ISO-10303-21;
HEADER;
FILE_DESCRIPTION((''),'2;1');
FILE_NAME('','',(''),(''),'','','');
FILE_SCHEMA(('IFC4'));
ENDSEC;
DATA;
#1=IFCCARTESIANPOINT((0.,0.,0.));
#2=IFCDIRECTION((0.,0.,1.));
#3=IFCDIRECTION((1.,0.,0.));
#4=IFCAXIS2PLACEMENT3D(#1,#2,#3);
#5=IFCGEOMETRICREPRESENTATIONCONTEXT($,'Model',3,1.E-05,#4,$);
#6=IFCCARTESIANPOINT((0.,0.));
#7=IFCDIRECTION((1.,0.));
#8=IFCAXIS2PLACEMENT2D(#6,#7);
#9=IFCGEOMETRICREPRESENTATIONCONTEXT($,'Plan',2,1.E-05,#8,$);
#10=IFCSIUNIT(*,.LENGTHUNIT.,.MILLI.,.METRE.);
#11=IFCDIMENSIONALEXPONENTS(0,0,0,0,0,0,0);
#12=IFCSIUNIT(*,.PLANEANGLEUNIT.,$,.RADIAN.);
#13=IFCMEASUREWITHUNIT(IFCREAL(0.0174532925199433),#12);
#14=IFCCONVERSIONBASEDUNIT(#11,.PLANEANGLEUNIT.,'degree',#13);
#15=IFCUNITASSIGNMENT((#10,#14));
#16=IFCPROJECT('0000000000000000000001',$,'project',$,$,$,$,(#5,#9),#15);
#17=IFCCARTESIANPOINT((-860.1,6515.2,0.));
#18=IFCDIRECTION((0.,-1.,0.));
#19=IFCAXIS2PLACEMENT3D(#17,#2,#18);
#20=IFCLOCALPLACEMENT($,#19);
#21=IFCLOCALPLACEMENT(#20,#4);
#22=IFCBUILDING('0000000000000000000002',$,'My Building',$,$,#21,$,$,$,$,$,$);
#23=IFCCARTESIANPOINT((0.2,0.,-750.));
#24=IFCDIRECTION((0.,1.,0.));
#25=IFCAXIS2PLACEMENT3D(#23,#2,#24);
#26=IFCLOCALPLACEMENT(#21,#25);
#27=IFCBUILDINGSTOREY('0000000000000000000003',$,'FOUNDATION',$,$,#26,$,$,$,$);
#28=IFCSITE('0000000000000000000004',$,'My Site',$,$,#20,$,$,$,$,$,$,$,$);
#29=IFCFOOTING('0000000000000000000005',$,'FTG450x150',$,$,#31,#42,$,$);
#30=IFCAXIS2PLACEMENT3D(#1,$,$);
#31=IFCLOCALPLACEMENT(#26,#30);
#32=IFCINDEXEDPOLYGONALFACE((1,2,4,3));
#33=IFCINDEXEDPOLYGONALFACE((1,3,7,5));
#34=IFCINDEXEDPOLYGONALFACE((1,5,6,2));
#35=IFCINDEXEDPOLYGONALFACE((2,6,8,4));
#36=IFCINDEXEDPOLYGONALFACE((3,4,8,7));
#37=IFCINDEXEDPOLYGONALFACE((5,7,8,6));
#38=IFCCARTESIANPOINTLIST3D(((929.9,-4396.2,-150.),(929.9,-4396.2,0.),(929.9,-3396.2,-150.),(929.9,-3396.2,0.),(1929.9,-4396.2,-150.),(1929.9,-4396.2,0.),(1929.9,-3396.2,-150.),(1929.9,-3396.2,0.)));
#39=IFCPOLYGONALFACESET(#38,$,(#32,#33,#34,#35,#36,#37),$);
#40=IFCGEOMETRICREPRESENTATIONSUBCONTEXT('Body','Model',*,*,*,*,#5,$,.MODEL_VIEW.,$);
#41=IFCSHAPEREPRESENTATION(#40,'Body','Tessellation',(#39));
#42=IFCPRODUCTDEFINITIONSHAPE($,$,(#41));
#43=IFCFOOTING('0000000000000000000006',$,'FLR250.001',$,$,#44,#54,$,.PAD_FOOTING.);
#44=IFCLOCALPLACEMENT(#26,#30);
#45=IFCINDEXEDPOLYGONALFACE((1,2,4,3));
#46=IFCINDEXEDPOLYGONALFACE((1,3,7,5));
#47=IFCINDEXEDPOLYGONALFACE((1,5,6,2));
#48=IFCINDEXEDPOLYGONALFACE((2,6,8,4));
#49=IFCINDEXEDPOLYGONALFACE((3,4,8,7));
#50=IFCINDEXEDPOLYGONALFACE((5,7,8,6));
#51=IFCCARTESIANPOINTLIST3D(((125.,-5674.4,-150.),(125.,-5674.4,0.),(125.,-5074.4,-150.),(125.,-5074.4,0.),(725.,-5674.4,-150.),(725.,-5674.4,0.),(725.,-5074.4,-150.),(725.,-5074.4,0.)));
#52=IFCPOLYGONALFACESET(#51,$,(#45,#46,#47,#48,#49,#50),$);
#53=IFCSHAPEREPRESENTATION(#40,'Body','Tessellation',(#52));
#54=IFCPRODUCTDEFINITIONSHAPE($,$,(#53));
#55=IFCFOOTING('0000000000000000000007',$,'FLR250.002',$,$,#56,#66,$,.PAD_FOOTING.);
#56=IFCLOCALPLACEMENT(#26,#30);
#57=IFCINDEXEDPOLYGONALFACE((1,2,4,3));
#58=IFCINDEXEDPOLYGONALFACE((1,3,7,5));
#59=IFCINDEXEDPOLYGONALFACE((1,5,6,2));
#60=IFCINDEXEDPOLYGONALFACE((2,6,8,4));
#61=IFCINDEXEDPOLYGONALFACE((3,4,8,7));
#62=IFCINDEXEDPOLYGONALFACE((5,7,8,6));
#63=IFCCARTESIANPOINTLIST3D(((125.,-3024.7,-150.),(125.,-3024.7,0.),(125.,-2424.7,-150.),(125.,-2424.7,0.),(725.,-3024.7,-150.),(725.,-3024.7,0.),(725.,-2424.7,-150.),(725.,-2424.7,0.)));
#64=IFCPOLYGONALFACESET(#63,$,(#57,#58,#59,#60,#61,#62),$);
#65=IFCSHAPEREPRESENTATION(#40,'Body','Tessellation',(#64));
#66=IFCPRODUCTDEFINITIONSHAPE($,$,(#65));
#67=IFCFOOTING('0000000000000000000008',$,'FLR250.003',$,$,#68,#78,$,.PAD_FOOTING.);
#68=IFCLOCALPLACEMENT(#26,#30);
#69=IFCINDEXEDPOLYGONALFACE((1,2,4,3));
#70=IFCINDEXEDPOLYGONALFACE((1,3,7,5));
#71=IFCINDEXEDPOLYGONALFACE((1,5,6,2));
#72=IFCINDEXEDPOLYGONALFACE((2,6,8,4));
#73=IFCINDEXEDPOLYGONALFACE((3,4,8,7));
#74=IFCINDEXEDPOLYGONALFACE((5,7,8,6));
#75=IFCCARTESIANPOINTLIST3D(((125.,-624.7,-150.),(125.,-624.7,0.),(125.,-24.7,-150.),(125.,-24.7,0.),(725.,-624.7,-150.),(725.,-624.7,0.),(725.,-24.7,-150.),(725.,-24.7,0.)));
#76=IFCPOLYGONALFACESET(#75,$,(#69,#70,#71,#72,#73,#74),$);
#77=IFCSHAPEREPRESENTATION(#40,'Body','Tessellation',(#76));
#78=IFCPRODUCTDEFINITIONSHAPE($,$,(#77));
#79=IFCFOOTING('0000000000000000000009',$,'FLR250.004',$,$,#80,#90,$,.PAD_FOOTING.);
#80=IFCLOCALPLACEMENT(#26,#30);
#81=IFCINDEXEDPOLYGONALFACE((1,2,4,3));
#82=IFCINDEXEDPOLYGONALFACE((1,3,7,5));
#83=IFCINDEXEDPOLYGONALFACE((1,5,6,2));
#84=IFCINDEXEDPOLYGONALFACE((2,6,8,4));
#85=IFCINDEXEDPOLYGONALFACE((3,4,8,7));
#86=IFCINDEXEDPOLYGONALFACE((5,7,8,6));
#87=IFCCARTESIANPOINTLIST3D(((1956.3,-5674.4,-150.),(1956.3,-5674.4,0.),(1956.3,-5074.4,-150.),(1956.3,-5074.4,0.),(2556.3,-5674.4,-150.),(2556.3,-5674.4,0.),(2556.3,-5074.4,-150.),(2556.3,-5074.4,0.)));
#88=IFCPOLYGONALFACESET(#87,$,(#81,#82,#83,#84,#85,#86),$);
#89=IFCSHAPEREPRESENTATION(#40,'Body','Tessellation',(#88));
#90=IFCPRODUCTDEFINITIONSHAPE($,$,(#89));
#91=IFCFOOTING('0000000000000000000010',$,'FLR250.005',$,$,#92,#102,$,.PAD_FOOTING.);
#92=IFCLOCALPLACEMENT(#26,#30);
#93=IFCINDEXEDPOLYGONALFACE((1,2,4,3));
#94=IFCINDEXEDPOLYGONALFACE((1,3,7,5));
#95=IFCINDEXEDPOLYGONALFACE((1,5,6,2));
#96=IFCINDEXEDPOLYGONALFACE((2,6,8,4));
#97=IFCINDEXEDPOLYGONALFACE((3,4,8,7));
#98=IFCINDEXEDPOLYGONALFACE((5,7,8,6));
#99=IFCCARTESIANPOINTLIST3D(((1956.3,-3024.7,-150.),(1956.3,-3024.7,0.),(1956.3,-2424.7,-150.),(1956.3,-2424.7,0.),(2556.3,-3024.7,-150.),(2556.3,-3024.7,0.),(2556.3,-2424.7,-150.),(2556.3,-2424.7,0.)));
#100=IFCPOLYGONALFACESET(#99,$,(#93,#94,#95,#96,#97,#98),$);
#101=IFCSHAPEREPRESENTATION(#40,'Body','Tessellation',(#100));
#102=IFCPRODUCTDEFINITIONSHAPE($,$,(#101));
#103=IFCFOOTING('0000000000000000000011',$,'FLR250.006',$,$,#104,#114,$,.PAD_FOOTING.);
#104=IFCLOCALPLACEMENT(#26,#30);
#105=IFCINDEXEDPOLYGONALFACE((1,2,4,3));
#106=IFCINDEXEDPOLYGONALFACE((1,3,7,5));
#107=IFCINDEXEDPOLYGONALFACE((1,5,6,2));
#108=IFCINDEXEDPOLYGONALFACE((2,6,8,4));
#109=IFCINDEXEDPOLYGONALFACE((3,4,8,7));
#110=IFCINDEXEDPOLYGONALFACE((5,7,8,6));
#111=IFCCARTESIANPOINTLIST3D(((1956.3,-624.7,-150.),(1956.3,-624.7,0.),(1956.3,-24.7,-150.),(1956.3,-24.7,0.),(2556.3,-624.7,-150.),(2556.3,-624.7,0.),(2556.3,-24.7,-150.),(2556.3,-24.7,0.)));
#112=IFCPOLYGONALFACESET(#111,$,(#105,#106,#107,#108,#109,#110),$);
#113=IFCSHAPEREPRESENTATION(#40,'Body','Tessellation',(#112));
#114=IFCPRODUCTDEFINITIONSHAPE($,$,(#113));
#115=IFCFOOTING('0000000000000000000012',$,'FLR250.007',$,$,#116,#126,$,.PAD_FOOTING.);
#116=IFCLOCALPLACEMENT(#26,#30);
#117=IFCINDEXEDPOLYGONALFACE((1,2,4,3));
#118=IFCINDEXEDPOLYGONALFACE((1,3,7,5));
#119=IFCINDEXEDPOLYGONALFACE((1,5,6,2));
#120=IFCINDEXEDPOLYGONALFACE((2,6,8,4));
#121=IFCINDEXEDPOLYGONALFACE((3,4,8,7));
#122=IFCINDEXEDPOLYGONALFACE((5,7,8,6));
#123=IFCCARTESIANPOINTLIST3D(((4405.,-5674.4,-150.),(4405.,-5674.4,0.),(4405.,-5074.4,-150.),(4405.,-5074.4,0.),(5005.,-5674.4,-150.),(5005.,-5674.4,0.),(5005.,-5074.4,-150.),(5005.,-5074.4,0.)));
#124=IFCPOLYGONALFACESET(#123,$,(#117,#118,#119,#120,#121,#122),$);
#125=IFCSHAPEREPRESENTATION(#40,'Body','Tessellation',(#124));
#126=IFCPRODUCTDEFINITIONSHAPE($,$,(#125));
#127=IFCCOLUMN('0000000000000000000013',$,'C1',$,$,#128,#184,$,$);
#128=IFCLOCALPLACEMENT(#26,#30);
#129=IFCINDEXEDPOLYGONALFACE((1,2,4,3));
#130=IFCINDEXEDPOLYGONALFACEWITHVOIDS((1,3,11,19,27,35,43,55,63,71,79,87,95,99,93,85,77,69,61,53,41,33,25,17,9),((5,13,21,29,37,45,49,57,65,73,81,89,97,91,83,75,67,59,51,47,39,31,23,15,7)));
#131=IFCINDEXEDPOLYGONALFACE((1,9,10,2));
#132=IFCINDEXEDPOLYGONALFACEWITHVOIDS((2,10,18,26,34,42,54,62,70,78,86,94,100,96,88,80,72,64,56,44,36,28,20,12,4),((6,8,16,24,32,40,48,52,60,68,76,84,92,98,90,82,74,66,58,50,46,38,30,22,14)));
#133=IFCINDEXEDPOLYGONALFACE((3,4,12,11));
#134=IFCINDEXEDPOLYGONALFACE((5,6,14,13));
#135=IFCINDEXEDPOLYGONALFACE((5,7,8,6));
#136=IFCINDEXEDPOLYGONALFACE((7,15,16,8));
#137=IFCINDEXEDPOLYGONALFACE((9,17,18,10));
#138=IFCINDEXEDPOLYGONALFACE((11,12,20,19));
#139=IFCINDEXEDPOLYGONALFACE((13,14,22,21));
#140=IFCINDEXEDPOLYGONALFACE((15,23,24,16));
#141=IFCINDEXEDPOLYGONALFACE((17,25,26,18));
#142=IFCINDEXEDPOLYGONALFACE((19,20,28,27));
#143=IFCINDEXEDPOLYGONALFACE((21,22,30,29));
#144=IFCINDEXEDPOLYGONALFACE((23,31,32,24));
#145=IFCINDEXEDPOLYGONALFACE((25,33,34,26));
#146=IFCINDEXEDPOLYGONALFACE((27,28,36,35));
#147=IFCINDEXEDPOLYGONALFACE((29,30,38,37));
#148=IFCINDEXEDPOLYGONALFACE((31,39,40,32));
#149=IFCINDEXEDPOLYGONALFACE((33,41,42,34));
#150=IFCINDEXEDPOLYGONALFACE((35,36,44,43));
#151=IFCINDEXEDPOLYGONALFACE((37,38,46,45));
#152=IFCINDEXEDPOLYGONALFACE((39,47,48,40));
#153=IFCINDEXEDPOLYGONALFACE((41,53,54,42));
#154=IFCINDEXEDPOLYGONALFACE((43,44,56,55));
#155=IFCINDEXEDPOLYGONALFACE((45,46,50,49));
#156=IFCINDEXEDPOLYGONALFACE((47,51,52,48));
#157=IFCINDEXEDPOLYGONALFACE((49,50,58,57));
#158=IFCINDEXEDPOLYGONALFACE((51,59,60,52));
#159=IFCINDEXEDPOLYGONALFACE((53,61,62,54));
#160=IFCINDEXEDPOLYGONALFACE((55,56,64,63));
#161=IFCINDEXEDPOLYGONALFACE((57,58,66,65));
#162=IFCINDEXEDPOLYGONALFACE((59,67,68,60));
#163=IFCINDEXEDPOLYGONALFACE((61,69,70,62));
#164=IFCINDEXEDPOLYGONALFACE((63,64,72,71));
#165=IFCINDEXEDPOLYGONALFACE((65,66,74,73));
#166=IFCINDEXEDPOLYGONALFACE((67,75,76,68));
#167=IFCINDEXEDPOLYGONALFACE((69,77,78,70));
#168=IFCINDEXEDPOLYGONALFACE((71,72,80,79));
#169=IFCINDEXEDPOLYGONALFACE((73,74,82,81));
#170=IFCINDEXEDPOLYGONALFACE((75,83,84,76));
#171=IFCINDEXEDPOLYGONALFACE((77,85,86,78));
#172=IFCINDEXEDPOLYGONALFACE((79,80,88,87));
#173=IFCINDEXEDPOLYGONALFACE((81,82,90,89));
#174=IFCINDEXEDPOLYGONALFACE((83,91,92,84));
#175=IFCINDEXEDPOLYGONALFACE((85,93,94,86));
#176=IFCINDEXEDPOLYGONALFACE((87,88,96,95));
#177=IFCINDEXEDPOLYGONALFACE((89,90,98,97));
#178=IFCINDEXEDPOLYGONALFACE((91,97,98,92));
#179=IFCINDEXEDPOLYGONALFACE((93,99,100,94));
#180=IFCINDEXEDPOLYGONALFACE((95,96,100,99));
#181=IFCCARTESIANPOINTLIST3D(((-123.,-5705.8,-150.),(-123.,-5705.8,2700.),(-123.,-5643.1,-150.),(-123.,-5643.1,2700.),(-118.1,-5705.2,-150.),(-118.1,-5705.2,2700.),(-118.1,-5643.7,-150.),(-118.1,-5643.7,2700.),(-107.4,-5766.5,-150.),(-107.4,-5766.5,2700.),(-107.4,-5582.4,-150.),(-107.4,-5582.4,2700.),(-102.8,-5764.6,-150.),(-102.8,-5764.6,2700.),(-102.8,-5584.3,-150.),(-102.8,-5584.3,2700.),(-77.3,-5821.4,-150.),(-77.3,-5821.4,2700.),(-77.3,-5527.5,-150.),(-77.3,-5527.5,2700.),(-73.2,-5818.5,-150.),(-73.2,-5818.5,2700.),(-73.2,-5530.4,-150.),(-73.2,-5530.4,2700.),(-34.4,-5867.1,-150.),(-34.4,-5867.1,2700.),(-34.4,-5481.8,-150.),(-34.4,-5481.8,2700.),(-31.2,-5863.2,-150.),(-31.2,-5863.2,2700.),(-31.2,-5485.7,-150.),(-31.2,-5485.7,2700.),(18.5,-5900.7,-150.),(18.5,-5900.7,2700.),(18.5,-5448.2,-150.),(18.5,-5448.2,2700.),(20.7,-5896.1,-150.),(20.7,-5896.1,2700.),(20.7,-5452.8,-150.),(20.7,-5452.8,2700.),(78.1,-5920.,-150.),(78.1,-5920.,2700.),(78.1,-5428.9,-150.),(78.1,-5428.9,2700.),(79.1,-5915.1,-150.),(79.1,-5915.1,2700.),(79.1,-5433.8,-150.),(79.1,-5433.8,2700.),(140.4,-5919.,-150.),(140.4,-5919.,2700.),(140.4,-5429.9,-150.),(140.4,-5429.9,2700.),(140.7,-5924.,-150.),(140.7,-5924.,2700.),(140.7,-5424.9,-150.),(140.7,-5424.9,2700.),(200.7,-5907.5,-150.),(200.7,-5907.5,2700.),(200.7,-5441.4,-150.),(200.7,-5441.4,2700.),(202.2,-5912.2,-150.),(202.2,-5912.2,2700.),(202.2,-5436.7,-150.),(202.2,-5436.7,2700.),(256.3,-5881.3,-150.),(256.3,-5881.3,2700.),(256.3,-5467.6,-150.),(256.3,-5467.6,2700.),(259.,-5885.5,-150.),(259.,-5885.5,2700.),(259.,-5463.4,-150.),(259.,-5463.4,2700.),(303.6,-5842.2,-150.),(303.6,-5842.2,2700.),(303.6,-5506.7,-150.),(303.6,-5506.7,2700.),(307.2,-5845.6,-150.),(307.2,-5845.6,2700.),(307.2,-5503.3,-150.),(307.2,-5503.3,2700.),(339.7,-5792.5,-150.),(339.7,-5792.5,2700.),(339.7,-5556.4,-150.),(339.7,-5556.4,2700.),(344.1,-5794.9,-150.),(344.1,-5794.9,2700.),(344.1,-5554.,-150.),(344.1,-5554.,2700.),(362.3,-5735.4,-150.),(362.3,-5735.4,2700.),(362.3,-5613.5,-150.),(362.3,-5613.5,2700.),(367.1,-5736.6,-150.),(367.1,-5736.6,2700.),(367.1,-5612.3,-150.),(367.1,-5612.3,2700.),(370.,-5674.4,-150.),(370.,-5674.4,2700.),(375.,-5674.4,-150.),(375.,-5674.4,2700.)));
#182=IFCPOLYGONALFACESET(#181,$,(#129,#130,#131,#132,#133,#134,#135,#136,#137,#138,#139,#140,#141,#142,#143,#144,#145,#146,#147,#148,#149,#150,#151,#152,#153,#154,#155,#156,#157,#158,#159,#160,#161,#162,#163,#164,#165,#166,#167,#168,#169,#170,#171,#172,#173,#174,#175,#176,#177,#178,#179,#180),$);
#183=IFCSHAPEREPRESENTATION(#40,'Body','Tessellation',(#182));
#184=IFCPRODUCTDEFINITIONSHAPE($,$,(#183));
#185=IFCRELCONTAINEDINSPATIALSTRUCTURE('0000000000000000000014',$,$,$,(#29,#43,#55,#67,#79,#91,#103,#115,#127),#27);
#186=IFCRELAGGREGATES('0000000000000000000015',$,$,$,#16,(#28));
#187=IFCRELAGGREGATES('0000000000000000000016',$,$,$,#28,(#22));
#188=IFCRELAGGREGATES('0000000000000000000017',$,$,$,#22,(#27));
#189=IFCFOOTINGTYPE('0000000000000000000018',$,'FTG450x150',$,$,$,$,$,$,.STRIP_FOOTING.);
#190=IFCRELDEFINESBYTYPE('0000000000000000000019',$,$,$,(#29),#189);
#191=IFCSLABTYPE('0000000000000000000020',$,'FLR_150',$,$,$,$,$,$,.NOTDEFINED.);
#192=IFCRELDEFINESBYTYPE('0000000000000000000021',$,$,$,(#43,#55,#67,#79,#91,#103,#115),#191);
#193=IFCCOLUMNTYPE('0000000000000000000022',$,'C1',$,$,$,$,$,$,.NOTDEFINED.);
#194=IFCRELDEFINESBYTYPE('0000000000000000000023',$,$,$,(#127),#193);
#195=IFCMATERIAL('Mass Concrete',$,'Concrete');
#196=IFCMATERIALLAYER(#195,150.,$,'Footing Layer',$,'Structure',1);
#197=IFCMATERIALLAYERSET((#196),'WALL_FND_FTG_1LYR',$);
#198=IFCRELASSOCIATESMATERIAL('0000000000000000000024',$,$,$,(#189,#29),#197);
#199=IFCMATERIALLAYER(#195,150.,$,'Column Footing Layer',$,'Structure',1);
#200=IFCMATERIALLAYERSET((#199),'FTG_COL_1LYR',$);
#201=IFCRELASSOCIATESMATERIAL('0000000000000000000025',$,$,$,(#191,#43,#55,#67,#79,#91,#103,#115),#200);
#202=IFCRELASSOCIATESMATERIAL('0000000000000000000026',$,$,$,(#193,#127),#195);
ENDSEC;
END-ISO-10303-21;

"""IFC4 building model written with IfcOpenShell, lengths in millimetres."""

from ifc_helpers import new_model, entity, si_unit, converted_unit, frame, origin_with_axes, origin_2d_with_axis, place, context, subcontext, project, spatial, line, indexed_curve, rectangle, hollow_circle, outline, extrude, material, layer, layer_set, layer_usage, material_profile, profile_set, profile_usage, type_object, element, save


model = new_model("IFC4")

# Units and contexts
model_context = context("Model", 3, precision=1e-05, world=origin_with_axes())
plan_context = context("Plan", 2, precision=1e-05, world=origin_2d_with_axis())
body_context = subcontext(model_context, "Body", "Model", "MODEL_VIEW")
ifc_project = project(units=[si_unit("LENGTHUNIT", "METRE", prefix="MILLI"), converted_unit("PLANEANGLEUNIT", "degree", entity("IfcReal", 0.0174532925199433), si_unit("PLANEANGLEUNIT", "RADIAN"), dimensions=[0, 0, 0, 0, 0, 0, 0])], contexts=[model_context, plan_context])

# Site, building, storey
site_placement = place(None, frame((-860.1, 6515.2, 0.0), z_axis=(0.0, 0.0, 1.0), x_axis=(0.0, -1.0, 0.0)))
site = spatial("IfcSite", under=ifc_project, at=site_placement, Name="My Site")
building_placement = place(site_placement, frame((0.0, 0.0, 0.0), z_axis=(0.0, 0.0, 1.0), x_axis=(1.0, 0.0, 0.0)))
building = spatial("IfcBuilding", under=site, at=building_placement, Name="My Building")
storey_placement = place(building_placement, frame((0.2, 0.0, -750.0), z_axis=(0.0, 0.0, 1.0), x_axis=(0.0, 1.0, 0.0)))
storey = spatial("IfcBuildingStorey", under=building, at=storey_placement, Name="FOUNDATION")

# Footings
ifc_material_1 = material(Name="Mass Concrete", Category="Concrete")
ifc_layer_1 = layer(ifc_material_1, 150.0, Name="Footing Layer", Category="Structure", Priority=1)
ifc_layer_set_1 = layer_set([ifc_layer_1], Name="WALL_FND_FTG_1LYR")
footing_type = type_object("IfcFootingType", Name="FTG450x150", PredefinedType="STRIP_FOOTING", material=ifc_layer_set_1)
ifc_layer_usage_1 = layer_usage(ifc_layer_set_1, "AXIS2", "POSITIVE", 0.0)
footing_1_placement = place(storey_placement, frame((929.9, -4396.2, -150.0), z_axis=(0.0, 0.0, 1.0), x_axis=(1.0, 0.0, 0.0)))
element("IfcFooting", 1, at=footing_1_placement, inside=storey, type_object=footing_type, material=ifc_layer_usage_1, Name="FTG450x150", context=body_context, shape_type="SweptSolid", body=[
    extrude(outline(indexed_curve([(0.0, 0.0), (1000.0, 0.0), (1000.0, 1000.0), (0.0, 1000.0), (0.0, 0.0)])), None, (0.0, 0.0, 1.0), 150.0),
])
ifc_layer_2 = layer(ifc_material_1, 150.0, Name="Column Footing Layer", Category="Structure", Priority=1)
ifc_layer_set_2 = layer_set([ifc_layer_2], Name="FTG_COL_1LYR")
ifc_layer_usage_2 = layer_usage(ifc_layer_set_2, "AXIS3", "POSITIVE", 0.0)
slab_type_1 = type_object("IfcSlabType", Name="FLR_150", PredefinedType="NOTDEFINED", material=ifc_layer_set_2)
footing_2_placement = place(storey_placement, frame((125.0, -5674.4, -150.0), z_axis=(0.0, 0.0, 1.0), x_axis=(1.0, 0.0, 0.0)))
element("IfcFooting", 2, at=footing_2_placement, inside=storey, type_object=slab_type_1, material=ifc_layer_usage_2, Name="FLR250.001", PredefinedType="PAD_FOOTING", context=body_context, shape_type="SweptSolid", body=[
    extrude(outline(indexed_curve([(0.0, 0.0), (600.0, 0.0), (600.0, 600.0), (0.0, 600.0)], segments=[line(3, 2), line(2, 1), line(1, 4), line(4, 3)], self_intersect=False)), None, (0.0, 0.0, 1.0), 150.0),
])
ifc_layer_usage_3 = layer_usage(ifc_layer_set_2, "AXIS3", "POSITIVE", 0.0)
footing_3_placement = place(storey_placement, frame((125.0, -3024.7, -150.0), z_axis=(0.0, 0.0, 1.0), x_axis=(1.0, 0.0, 0.0)))
element("IfcFooting", 3, at=footing_3_placement, inside=storey, type_object=slab_type_1, material=ifc_layer_usage_3, Name="FLR250.002", PredefinedType="PAD_FOOTING", context=body_context, shape_type="SweptSolid", body=[
    extrude(outline(indexed_curve([(0.0, 0.0), (600.0, 0.0), (600.0, 600.0), (0.0, 600.0)], segments=[line(3, 2), line(2, 1), line(1, 4), line(4, 3)], self_intersect=False)), None, (0.0, 0.0, 1.0), 150.0),
])
ifc_layer_usage_4 = layer_usage(ifc_layer_set_2, "AXIS3", "POSITIVE", 0.0)
footing_4_placement = place(storey_placement, frame((125.0, -624.7, -150.0), z_axis=(0.0, 0.0, 1.0), x_axis=(1.0, 0.0, 0.0)))
element("IfcFooting", 4, at=footing_4_placement, inside=storey, type_object=slab_type_1, material=ifc_layer_usage_4, Name="FLR250.003", PredefinedType="PAD_FOOTING", context=body_context, shape_type="SweptSolid", body=[
    extrude(outline(indexed_curve([(0.0, 0.0), (600.0, 0.0), (600.0, 600.0), (0.0, 600.0)], segments=[line(3, 2), line(2, 1), line(1, 4), line(4, 3)], self_intersect=False)), None, (0.0, 0.0, 1.0), 150.0),
])
ifc_layer_usage_5 = layer_usage(ifc_layer_set_2, "AXIS3", "POSITIVE", 0.0)
footing_5_placement = place(storey_placement, frame((1956.3, -5674.4, -150.0), z_axis=(0.0, 0.0, 1.0), x_axis=(1.0, 0.0, 0.0)))
element("IfcFooting", 5, at=footing_5_placement, inside=storey, type_object=slab_type_1, material=ifc_layer_usage_5, Name="FLR250.004", PredefinedType="PAD_FOOTING", context=body_context, shape_type="SweptSolid", body=[
    extrude(outline(indexed_curve([(0.0, 0.0), (600.0, 0.0), (600.0, 600.0), (0.0, 600.0)], segments=[line(3, 2), line(2, 1), line(1, 4), line(4, 3)], self_intersect=False)), None, (0.0, 0.0, 1.0), 150.0),
])
ifc_layer_usage_6 = layer_usage(ifc_layer_set_2, "AXIS3", "POSITIVE", 0.0)
footing_6_placement = place(storey_placement, frame((1956.3, -3024.7, -150.0), z_axis=(0.0, 0.0, 1.0), x_axis=(1.0, 0.0, 0.0)))
element("IfcFooting", 6, at=footing_6_placement, inside=storey, type_object=slab_type_1, material=ifc_layer_usage_6, Name="FLR250.005", PredefinedType="PAD_FOOTING", context=body_context, shape_type="SweptSolid", body=[
    extrude(outline(indexed_curve([(0.0, 0.0), (600.0, 0.0), (600.0, 600.0), (0.0, 600.0)], segments=[line(3, 2), line(2, 1), line(1, 4), line(4, 3)], self_intersect=False)), None, (0.0, 0.0, 1.0), 150.0),
])
ifc_layer_usage_7 = layer_usage(ifc_layer_set_2, "AXIS3", "POSITIVE", 0.0)
footing_7_placement = place(storey_placement, frame((1956.3, -624.7, -150.0), z_axis=(0.0, 0.0, 1.0), x_axis=(1.0, 0.0, 0.0)))
element("IfcFooting", 7, at=footing_7_placement, inside=storey, type_object=slab_type_1, material=ifc_layer_usage_7, Name="FLR250.006", PredefinedType="PAD_FOOTING", context=body_context, shape_type="SweptSolid", body=[
    extrude(outline(indexed_curve([(0.0, 0.0), (600.0, 0.0), (600.0, 600.0), (0.0, 600.0)], segments=[line(3, 2), line(2, 1), line(1, 4), line(4, 3)], self_intersect=False)), None, (0.0, 0.0, 1.0), 150.0),
])
ifc_layer_usage_8 = layer_usage(ifc_layer_set_2, "AXIS3", "POSITIVE", 0.0)
footing_8_placement = place(storey_placement, frame((4405.0, -5674.4, -150.0), z_axis=(0.0, 0.0, 1.0), x_axis=(1.0, 0.0, 0.0)))
element("IfcFooting", 8, at=footing_8_placement, inside=storey, type_object=slab_type_1, material=ifc_layer_usage_8, Name="FLR250.007", PredefinedType="PAD_FOOTING", context=body_context, shape_type="SweptSolid", body=[
    extrude(outline(indexed_curve([(0.0, 0.0), (600.0, 0.0), (600.0, 600.0), (0.0, 600.0)], segments=[line(3, 2), line(2, 1), line(1, 4), line(4, 3)], self_intersect=False)), None, (0.0, 0.0, 1.0), 150.0),
])

# Column
ifc_material_profile = material_profile(ifc_material_1, rectangle(XDim=150.0, YDim=150.0), Name="Square Column", Category="Structure", Priority=1)
ifc_profile_set = profile_set([ifc_material_profile], Name="RC_COL_150x150")
ifc_profile_usage_1 = profile_usage(ifc_profile_set, cardinal=5)
column_type = type_object("IfcColumnType", Name="C1", PredefinedType="NOTDEFINED", material=ifc_profile_set)
column_1_placement = place(storey_placement, frame((125.0, -5674.4, -150.0), z_axis=(0.0, 0.0, 1.0), x_axis=(1.0, 0.0, 0.0)))
element("IfcColumn", 9, at=column_1_placement, inside=storey, type_object=column_type, material=ifc_profile_usage_1, Name="C1", context=body_context, shape_type="SweptSolid", body=[
    extrude(hollow_circle(Radius=250.0, WallThickness=5.0), origin_with_axes(), (0.0, 0.0, 1.0), 2850.0),
])

save(model, "model.ifc")
